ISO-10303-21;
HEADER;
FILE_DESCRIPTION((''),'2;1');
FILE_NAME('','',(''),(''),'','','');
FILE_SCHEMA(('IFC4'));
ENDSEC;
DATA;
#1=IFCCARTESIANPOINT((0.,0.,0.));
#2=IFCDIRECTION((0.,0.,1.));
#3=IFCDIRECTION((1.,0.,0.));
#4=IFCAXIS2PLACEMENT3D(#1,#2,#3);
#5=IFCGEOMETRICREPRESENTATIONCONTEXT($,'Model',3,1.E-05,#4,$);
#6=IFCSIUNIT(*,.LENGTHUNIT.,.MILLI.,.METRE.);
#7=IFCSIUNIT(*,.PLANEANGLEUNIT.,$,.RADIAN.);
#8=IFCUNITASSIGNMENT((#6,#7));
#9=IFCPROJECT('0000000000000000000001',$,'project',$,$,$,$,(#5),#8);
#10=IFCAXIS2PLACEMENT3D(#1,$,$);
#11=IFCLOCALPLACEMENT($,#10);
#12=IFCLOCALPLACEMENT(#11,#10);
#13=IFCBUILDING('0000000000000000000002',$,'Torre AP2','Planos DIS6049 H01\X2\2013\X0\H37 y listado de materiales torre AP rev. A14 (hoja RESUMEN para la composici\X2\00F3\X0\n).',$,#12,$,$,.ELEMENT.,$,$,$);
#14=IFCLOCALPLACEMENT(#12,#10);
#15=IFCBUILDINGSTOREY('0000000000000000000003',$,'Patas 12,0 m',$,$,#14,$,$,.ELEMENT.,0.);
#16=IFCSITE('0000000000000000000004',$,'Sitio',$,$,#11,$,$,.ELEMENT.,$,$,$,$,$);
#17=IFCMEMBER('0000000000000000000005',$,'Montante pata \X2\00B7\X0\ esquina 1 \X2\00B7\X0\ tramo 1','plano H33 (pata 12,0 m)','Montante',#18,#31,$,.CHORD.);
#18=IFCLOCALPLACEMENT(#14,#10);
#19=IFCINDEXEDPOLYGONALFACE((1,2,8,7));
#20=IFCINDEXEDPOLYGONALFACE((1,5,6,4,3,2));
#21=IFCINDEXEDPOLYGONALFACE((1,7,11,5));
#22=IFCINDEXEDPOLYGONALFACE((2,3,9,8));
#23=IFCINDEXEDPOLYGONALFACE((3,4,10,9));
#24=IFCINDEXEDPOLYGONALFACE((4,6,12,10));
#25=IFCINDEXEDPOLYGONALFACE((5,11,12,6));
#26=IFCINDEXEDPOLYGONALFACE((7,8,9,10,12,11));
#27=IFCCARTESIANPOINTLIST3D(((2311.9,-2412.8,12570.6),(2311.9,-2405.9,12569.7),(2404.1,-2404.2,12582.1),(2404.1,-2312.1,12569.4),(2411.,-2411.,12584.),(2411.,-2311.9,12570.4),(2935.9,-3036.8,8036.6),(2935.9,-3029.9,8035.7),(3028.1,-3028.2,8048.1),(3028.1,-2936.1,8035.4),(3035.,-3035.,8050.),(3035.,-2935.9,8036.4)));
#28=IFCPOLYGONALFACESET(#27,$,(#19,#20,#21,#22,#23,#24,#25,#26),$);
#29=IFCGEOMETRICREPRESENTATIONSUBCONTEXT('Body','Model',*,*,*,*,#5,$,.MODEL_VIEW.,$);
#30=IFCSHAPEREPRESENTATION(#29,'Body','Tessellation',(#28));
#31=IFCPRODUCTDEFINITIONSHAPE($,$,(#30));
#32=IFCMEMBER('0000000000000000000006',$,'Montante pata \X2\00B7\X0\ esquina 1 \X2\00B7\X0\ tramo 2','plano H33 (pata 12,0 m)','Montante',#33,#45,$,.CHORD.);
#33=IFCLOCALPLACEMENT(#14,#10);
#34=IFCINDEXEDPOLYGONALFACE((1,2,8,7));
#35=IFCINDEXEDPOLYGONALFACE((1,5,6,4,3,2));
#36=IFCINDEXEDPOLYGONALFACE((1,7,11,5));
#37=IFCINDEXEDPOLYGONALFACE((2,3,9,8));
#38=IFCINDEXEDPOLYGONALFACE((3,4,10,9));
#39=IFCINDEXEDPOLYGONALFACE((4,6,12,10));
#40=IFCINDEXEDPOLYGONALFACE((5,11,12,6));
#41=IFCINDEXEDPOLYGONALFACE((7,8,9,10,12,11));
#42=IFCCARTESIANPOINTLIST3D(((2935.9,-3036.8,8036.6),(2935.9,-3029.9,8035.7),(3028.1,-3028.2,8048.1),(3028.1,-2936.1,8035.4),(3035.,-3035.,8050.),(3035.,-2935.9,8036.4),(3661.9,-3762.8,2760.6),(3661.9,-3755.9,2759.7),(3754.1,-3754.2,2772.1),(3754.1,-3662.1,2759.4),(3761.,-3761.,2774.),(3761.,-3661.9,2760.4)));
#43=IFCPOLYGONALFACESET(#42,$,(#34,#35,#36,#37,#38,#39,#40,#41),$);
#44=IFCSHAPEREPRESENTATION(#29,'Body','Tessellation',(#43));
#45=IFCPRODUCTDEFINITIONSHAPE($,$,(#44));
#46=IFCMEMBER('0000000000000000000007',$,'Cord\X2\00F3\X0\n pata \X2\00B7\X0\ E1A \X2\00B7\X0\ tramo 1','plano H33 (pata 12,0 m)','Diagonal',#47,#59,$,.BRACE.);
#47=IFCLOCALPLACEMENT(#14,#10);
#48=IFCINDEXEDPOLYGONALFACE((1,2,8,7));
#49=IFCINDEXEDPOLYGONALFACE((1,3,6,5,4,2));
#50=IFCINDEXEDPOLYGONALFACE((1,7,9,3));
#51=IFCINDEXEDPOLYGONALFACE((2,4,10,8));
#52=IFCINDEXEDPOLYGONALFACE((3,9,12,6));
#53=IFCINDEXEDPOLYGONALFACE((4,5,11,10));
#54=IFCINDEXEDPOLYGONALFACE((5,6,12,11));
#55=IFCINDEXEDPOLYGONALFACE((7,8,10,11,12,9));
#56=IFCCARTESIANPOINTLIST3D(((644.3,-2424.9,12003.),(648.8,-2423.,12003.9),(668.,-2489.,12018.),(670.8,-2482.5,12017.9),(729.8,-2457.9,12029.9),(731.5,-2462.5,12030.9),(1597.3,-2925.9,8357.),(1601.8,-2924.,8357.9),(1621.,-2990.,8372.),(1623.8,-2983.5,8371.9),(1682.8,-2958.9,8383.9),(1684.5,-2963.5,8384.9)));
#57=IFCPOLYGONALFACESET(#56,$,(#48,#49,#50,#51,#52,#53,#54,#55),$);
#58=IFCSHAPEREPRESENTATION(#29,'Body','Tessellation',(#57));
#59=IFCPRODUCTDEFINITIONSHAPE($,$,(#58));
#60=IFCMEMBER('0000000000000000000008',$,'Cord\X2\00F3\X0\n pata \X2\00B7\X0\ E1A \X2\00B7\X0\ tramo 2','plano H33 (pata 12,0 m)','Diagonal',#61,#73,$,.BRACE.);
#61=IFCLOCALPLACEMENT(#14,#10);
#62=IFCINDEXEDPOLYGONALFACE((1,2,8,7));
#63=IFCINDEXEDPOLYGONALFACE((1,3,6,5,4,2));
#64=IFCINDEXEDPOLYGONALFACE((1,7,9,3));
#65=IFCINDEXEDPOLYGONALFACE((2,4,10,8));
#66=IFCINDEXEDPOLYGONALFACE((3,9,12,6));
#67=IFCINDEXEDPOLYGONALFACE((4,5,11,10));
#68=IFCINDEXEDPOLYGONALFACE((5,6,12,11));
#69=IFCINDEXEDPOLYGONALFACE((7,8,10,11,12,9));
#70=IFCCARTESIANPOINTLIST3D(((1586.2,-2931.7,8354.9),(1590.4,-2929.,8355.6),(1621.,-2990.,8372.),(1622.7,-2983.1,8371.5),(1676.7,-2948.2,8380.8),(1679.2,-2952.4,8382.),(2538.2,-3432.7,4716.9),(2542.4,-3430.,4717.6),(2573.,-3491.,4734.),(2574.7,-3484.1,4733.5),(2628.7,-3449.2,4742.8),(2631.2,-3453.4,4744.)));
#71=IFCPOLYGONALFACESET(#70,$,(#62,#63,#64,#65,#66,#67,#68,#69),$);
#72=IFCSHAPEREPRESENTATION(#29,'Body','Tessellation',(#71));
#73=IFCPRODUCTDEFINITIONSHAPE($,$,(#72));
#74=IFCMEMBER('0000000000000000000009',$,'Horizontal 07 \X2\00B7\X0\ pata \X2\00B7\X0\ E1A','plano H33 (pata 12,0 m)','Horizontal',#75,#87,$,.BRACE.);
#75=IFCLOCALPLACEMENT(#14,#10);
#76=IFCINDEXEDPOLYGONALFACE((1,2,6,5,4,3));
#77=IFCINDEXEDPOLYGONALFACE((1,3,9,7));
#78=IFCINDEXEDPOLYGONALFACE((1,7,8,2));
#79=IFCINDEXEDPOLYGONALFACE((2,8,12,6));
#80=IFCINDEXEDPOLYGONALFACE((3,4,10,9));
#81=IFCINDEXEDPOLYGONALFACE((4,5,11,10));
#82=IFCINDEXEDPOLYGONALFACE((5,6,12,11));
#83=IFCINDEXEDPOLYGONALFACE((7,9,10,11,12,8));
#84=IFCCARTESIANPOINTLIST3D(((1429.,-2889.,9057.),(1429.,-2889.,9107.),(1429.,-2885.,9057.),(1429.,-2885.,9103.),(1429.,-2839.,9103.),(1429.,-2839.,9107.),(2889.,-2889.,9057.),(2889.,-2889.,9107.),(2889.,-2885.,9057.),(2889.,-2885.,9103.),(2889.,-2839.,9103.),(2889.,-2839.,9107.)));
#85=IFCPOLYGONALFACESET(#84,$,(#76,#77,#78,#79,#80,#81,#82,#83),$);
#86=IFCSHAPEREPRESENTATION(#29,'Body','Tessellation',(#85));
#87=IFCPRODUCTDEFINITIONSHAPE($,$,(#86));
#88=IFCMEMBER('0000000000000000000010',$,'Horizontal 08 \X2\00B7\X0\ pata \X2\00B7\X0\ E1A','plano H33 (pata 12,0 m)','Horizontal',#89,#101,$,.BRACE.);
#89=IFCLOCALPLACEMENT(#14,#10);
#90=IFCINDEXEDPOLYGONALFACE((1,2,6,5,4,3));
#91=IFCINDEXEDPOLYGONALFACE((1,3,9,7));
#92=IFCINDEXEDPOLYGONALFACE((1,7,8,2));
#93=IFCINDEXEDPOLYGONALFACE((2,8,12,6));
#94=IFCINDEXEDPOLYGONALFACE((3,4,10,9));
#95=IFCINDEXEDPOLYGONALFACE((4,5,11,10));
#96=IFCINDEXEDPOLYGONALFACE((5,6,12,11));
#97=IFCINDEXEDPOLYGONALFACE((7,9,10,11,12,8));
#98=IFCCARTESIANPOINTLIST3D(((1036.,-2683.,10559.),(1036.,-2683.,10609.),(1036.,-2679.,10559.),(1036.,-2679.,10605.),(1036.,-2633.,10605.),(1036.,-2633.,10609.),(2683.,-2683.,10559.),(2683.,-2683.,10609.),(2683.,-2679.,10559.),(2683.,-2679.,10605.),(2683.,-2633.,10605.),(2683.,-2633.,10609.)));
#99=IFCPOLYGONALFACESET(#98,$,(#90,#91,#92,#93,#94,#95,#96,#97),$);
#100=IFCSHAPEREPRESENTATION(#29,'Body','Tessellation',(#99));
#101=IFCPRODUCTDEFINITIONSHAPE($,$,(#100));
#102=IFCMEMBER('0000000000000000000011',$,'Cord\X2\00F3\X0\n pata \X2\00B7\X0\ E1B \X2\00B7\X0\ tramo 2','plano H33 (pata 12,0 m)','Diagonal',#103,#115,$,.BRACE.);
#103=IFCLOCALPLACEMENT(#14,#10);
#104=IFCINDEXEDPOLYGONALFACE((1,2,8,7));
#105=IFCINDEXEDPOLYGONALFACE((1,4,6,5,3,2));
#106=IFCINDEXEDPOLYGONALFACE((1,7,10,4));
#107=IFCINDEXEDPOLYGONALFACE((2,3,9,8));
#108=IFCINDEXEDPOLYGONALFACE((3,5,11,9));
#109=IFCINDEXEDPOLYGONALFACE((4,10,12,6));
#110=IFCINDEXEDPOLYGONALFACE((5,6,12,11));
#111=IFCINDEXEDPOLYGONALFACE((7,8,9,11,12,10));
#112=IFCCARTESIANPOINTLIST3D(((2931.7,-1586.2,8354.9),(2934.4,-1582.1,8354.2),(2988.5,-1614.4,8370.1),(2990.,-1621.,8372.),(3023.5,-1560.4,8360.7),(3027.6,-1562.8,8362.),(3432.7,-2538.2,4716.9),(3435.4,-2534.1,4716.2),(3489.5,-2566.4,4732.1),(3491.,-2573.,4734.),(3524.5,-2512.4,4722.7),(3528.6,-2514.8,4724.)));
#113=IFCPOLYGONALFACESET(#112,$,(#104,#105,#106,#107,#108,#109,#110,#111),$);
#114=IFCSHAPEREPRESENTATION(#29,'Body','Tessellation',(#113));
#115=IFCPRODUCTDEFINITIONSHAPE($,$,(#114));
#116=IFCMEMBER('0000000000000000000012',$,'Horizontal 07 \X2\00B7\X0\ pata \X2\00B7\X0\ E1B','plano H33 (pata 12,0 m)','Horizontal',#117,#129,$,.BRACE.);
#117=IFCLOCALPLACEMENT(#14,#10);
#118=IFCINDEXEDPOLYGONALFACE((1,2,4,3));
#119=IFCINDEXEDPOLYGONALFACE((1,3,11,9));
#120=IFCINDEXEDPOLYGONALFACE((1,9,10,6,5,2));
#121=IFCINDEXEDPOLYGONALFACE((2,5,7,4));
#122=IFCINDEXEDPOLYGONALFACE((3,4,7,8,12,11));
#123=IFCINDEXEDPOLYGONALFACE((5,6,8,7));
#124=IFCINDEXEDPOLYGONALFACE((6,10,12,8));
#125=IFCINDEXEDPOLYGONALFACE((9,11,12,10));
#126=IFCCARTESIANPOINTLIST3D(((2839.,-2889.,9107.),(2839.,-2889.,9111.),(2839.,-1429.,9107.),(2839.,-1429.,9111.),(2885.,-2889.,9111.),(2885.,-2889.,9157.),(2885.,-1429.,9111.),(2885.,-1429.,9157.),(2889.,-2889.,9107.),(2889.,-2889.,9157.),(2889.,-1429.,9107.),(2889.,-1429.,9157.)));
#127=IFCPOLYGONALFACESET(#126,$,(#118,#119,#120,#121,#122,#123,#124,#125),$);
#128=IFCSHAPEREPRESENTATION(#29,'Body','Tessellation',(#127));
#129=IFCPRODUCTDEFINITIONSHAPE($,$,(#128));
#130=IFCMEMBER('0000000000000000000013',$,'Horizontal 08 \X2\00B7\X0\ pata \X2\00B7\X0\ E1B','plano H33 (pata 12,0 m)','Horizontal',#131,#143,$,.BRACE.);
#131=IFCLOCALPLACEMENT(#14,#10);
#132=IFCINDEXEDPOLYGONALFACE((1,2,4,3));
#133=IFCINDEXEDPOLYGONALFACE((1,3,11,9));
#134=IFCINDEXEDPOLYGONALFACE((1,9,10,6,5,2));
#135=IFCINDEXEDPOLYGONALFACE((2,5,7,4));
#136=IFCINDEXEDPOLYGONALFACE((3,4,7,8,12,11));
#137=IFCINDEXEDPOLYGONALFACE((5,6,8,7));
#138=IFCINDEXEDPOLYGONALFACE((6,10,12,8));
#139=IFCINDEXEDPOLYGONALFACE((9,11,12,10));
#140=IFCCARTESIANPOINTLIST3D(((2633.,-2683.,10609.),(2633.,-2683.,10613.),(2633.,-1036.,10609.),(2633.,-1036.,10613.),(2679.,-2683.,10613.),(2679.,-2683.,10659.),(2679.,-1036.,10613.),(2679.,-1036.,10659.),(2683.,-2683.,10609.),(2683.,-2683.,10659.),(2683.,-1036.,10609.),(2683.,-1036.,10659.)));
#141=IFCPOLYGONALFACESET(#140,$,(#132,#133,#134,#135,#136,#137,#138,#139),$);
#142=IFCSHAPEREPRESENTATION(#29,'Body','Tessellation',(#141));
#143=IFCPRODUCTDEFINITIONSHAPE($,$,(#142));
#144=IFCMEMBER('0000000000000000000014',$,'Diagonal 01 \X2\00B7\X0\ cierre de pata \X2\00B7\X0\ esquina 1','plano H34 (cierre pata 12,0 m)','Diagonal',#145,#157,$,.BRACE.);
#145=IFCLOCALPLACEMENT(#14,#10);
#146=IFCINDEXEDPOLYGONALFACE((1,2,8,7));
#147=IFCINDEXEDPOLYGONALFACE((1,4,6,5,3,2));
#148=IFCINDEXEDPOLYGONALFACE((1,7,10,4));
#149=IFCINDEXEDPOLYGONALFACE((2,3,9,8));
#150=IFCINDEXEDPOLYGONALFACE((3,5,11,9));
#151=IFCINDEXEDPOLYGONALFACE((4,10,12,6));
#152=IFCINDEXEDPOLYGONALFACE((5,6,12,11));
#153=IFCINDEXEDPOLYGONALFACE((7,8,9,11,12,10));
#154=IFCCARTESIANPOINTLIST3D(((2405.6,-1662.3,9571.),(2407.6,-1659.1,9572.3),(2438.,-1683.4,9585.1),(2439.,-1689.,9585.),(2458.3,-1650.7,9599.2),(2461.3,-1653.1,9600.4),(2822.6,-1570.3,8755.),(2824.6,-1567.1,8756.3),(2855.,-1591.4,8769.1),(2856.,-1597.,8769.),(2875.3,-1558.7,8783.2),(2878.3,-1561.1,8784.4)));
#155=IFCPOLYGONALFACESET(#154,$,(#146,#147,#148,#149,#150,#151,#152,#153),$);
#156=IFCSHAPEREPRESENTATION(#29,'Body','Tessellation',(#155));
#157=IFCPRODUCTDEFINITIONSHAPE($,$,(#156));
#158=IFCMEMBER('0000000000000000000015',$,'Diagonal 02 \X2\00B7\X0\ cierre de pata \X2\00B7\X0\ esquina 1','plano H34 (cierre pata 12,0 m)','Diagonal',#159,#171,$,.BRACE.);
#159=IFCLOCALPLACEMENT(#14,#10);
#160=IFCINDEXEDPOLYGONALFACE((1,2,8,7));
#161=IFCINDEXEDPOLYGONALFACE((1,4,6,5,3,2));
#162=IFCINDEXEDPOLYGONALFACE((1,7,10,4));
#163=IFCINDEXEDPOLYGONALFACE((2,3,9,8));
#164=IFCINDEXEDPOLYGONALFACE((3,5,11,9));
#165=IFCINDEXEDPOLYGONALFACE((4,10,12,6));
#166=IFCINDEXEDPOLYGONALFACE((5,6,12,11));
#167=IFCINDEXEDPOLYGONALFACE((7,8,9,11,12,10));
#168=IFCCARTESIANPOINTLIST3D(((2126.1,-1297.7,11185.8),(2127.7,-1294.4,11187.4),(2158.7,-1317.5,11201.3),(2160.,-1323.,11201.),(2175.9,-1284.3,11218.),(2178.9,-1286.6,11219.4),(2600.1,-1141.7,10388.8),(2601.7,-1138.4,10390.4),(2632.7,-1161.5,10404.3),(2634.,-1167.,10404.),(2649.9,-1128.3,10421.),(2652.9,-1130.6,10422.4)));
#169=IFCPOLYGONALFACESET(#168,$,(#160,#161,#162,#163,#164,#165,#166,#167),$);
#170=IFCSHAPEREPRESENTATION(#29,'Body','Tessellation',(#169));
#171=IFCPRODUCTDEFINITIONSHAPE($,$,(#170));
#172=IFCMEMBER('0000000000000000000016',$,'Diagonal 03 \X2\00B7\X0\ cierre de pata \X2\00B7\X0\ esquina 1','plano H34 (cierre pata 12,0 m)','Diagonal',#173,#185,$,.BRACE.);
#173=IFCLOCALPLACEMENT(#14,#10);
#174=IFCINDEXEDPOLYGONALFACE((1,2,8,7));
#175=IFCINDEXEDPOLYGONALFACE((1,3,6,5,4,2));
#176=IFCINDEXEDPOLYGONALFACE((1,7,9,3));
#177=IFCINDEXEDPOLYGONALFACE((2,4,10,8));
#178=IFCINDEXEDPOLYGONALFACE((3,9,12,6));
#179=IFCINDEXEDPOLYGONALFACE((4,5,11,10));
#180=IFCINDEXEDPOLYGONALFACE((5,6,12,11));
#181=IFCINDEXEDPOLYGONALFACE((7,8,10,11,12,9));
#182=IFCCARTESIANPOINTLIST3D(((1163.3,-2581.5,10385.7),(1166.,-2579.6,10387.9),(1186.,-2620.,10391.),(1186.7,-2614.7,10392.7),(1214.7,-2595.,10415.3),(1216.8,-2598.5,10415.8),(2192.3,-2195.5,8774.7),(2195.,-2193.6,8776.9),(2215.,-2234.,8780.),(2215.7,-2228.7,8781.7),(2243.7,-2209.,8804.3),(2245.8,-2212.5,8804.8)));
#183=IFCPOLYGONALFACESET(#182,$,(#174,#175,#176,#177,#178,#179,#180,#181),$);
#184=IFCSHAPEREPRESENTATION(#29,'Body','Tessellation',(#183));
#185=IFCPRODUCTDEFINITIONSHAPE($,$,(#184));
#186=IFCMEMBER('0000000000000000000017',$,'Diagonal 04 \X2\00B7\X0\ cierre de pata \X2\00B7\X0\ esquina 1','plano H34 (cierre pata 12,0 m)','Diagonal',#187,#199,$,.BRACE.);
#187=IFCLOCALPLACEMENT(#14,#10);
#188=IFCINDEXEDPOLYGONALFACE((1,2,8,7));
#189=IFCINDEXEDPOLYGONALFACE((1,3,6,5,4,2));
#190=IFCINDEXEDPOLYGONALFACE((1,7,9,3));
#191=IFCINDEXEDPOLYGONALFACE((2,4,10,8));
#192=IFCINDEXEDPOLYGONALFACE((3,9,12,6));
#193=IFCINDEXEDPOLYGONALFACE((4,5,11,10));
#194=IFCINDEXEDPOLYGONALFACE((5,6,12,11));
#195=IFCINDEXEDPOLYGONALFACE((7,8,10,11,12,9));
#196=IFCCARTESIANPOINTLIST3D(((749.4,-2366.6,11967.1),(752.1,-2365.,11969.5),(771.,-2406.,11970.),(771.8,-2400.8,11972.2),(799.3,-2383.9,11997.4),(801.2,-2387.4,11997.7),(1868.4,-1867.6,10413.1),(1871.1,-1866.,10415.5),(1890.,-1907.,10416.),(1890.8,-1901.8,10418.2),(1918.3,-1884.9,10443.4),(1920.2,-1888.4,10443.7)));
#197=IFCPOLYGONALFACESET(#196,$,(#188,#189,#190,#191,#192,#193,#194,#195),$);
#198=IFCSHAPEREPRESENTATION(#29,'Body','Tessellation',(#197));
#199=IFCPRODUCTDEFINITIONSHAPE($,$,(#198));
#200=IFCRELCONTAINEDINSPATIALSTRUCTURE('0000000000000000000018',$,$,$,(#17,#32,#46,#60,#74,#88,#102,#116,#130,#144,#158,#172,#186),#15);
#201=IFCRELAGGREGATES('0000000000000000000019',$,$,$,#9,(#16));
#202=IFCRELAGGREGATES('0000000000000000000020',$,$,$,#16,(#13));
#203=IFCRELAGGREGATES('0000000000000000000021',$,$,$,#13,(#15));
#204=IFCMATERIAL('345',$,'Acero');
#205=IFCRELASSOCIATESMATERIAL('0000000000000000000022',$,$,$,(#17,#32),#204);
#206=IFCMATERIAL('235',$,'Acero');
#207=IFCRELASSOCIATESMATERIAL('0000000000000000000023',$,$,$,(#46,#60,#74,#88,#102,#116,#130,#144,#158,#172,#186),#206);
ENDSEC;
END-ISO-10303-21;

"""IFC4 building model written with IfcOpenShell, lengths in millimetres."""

from ifc_helpers import new_model, si_unit, frame, frame_2d, origin, origin_with_axes, place, context, subcontext, project, spatial, l_section, extrude, material, element, save


model = new_model("IFC4")

# Units and contexts
model_context = context("Model", 3, precision=1e-05, world=origin_with_axes())
body_context = subcontext(model_context, "Body", "Model", "MODEL_VIEW")
ifc_project = project(units=[si_unit("LENGTHUNIT", "METRE", prefix="MILLI"), si_unit("PLANEANGLEUNIT", "RADIAN")], contexts=[model_context])

# Site, building, storey
site_placement = place(None, origin())
site = spatial("IfcSite", under=ifc_project, at=site_placement, Name="Sitio", CompositionType="ELEMENT")
building_placement = place(site_placement, origin())
building = spatial("IfcBuilding", under=site, at=building_placement, Name="Torre AP2", Description="Planos DIS6049 H01–H37 y listado de materiales torre AP rev. A14 (hoja RESUMEN para la composición).", CompositionType="ELEMENT")
storey_placement = place(building_placement, origin())
storey = spatial("IfcBuildingStorey", under=building, at=storey_placement, Name="Patas 12,0 m", CompositionType="ELEMENT", Elevation=0.0)

# Members
ifc_material_1 = material(Name="345", Category="Acero")
member_1_placement = place(storey_placement, frame((2411.0, -2411.0, 12584.0), z_axis=(0.135092, -0.135092, -0.981581), x_axis=(-0.990833, -0.018419, -0.13383)))
element("IfcMember", 1, at=member_1_placement, inside=storey, material=ifc_material_1, Name="Montante pata · esquina 1 · tramo 1", Description="plano H33 (pata 12,0 m)", ObjectType="Montante", PredefinedType="CHORD", context=body_context, shape_type="SweptSolid", body=[
    extrude(l_section(Depth=100.0, Width=100.0, Thickness=7.0, at=frame_2d((50.0, 50.0))), None, (0.0, 0.0, 1.0), 4619.1),
])
member_2_placement = place(storey_placement, frame((3035.0, -3035.0, 8050.0), z_axis=(0.13507, -0.13507, -0.981586), x_axis=(-0.990836, -0.018413, -0.13381)))
element("IfcMember", 2, at=member_2_placement, inside=storey, material=ifc_material_1, Name="Montante pata · esquina 1 · tramo 2", Description="plano H33 (pata 12,0 m)", ObjectType="Montante", PredefinedType="CHORD", context=body_context, shape_type="SweptSolid", body=[
    extrude(l_section(Depth=100.0, Width=100.0, Thickness=7.0, at=frame_2d((50.0, 50.0))), None, (0.0, 0.0, 1.0), 5375.0),
])
ifc_material_2 = material(Name="235", Category="Acero")
member_3_placement = place(storey_placement, frame((668.0, -2489.0, 12018.0), z_axis=(0.250681, -0.131785, -0.959058), x_axis=(-0.338951, 0.916032, -0.214469)))
element("IfcMember", 3, at=member_3_placement, inside=storey, material=ifc_material_2, Name="Cordón pata · E1A · tramo 1", Description="plano H33 (pata 12,0 m)", ObjectType="Diagonal", PredefinedType="BRACE", context=body_context, shape_type="SweptSolid", body=[
    extrude(l_section(Depth=70.0, Width=70.0, Thickness=5.0, at=frame_2d((35.0, 35.0))), None, (0.0, 0.0, 1.0), 3801.6),
])
member_4_placement = place(storey_placement, frame((1621.0, -2990.0, 8372.0), z_axis=(0.250941, -0.13206, -0.958952), x_axis=(-0.49667, 0.832746, -0.24465)))
element("IfcMember", 4, at=member_4_placement, inside=storey, material=ifc_material_2, Name="Cordón pata · E1A · tramo 2", Description="plano H33 (pata 12,0 m)", ObjectType="Diagonal", PredefinedType="BRACE", context=body_context, shape_type="SweptSolid", body=[
    extrude(l_section(Depth=70.0, Width=70.0, Thickness=5.0, at=frame_2d((35.0, 35.0))), None, (0.0, 0.0, 1.0), 3793.7),
])
member_5_placement = place(storey_placement, frame((2889.0, -2889.0, 9107.0), z_axis=(-1.0, 0.0, 0.0), x_axis=(0.0, 1.0, 0.0)))
element("IfcMember", 5, at=member_5_placement, inside=storey, material=ifc_material_2, Name="Horizontal 07 · pata · E1A", Description="plano H33 (pata 12,0 m)", ObjectType="Horizontal", PredefinedType="BRACE", context=body_context, shape_type="SweptSolid", body=[
    extrude(l_section(Depth=50.0, Width=50.0, Thickness=4.0, at=frame_2d((25.0, 25.0))), None, (0.0, 0.0, 1.0), 1460.0),
])
member_6_placement = place(storey_placement, frame((2683.0, -2683.0, 10609.0), z_axis=(-1.0, 0.0, 0.0), x_axis=(0.0, 1.0, 0.0)))
element("IfcMember", 6, at=member_6_placement, inside=storey, material=ifc_material_2, Name="Horizontal 08 · pata · E1A", Description="plano H33 (pata 12,0 m)", ObjectType="Horizontal", PredefinedType="BRACE", context=body_context, shape_type="SweptSolid", body=[
    extrude(l_section(Depth=50.0, Width=50.0, Thickness=4.0, at=frame_2d((25.0, 25.0))), None, (0.0, 0.0, 1.0), 1647.0),
])
member_7_placement = place(storey_placement, frame((2990.0, -1621.0, 8372.0), z_axis=(0.13206, -0.250941, -0.958952), x_axis=(-0.832746, 0.49667, -0.24465)))
element("IfcMember", 7, at=member_7_placement, inside=storey, material=ifc_material_2, Name="Cordón pata · E1B · tramo 2", Description="plano H33 (pata 12,0 m)", ObjectType="Diagonal", PredefinedType="BRACE", context=body_context, shape_type="SweptSolid", body=[
    extrude(l_section(Depth=70.0, Width=70.0, Thickness=5.0, at=frame_2d((35.0, 35.0))), None, (0.0, 0.0, 1.0), 3793.7),
])
member_8_placement = place(storey_placement, frame((2889.0, -2889.0, 9107.0), z_axis=(0.0, 1.0, 0.0), x_axis=(-1.0, 0.0, 0.0)))
element("IfcMember", 8, at=member_8_placement, inside=storey, material=ifc_material_2, Name="Horizontal 07 · pata · E1B", Description="plano H33 (pata 12,0 m)", ObjectType="Horizontal", PredefinedType="BRACE", context=body_context, shape_type="SweptSolid", body=[
    extrude(l_section(Depth=50.0, Width=50.0, Thickness=4.0, at=frame_2d((25.0, 25.0))), None, (0.0, 0.0, 1.0), 1460.0),
])
member_9_placement = place(storey_placement, frame((2683.0, -2683.0, 10609.0), z_axis=(0.0, 1.0, 0.0), x_axis=(-1.0, 0.0, 0.0)))
element("IfcMember", 9, at=member_9_placement, inside=storey, material=ifc_material_2, Name="Horizontal 08 · pata · E1B", Description="plano H33 (pata 12,0 m)", ObjectType="Horizontal", PredefinedType="BRACE", context=body_context, shape_type="SweptSolid", body=[
    extrude(l_section(Depth=50.0, Width=50.0, Thickness=4.0, at=frame_2d((25.0, 25.0))), None, (0.0, 0.0, 1.0), 1647.0),
])
member_10_placement = place(storey_placement, frame((2439.0, -1689.0, 9585.0), z_axis=(0.452777, 0.099893, -0.88601), x_axis=(-0.741403, 0.594179, -0.311888)))
element("IfcMember", 10, at=member_10_placement, inside=storey, material=ifc_material_2, Name="Diagonal 01 · cierre de pata · esquina 1", Description="plano H34 (cierre pata 12,0 m)", ObjectType="Diagonal", PredefinedType="BRACE", context=body_context, shape_type="SweptSolid", body=[
    extrude(l_section(Depth=45.0, Width=45.0, Thickness=4.0, at=frame_2d((22.5, 22.5))), None, (0.0, 0.0, 1.0), 921.0),
])
member_11_placement = place(storey_placement, frame((2160.0, -1323.0, 11201.0), z_axis=(0.504078, 0.165899, -0.847575), x_axis=(-0.754279, 0.56258, -0.338477)))
element("IfcMember", 11, at=member_11_placement, inside=storey, material=ifc_material_2, Name="Diagonal 02 · cierre de pata · esquina 1", Description="plano H34 (cierre pata 12,0 m)", ObjectType="Diagonal", PredefinedType="BRACE", context=body_context, shape_type="SweptSolid", body=[
    extrude(l_section(Depth=45.0, Width=45.0, Thickness=4.0, at=frame_2d((22.5, 22.5))), None, (0.0, 0.0, 1.0), 940.3),
])
member_12_placement = place(storey_placement, frame((1186.0, -2620.0, 10391.0), z_axis=(0.527647, 0.197932, -0.826082), x_axis=(-0.504616, 0.855328, -0.117376)))
element("IfcMember", 12, at=member_12_placement, inside=storey, material=ifc_material_2, Name="Diagonal 03 · cierre de pata · esquina 1", Description="plano H34 (cierre pata 12,0 m)", ObjectType="Diagonal", PredefinedType="BRACE", context=body_context, shape_type="SweptSolid", body=[
    extrude(l_section(Depth=45.0, Width=45.0, Thickness=4.0, at=frame_2d((22.5, 22.5))), None, (0.0, 0.0, 1.0), 1950.2),
])
member_13_placement = place(storey_placement, frame((771.0, -2406.0, 11970.0), z_axis=(0.565463, 0.252159, -0.785281), x_axis=(-0.480163, 0.874778, -0.064857)))
element("IfcMember", 13, at=member_13_placement, inside=storey, material=ifc_material_2, Name="Diagonal 04 · cierre de pata · esquina 1", Description="plano H34 (cierre pata 12,0 m)", ObjectType="Diagonal", PredefinedType="BRACE", context=body_context, shape_type="SweptSolid", body=[
    extrude(l_section(Depth=45.0, Width=45.0, Thickness=4.0, at=frame_2d((22.5, 22.5))), None, (0.0, 0.0, 1.0), 1978.9),
])

save(model, "model.ifc")
